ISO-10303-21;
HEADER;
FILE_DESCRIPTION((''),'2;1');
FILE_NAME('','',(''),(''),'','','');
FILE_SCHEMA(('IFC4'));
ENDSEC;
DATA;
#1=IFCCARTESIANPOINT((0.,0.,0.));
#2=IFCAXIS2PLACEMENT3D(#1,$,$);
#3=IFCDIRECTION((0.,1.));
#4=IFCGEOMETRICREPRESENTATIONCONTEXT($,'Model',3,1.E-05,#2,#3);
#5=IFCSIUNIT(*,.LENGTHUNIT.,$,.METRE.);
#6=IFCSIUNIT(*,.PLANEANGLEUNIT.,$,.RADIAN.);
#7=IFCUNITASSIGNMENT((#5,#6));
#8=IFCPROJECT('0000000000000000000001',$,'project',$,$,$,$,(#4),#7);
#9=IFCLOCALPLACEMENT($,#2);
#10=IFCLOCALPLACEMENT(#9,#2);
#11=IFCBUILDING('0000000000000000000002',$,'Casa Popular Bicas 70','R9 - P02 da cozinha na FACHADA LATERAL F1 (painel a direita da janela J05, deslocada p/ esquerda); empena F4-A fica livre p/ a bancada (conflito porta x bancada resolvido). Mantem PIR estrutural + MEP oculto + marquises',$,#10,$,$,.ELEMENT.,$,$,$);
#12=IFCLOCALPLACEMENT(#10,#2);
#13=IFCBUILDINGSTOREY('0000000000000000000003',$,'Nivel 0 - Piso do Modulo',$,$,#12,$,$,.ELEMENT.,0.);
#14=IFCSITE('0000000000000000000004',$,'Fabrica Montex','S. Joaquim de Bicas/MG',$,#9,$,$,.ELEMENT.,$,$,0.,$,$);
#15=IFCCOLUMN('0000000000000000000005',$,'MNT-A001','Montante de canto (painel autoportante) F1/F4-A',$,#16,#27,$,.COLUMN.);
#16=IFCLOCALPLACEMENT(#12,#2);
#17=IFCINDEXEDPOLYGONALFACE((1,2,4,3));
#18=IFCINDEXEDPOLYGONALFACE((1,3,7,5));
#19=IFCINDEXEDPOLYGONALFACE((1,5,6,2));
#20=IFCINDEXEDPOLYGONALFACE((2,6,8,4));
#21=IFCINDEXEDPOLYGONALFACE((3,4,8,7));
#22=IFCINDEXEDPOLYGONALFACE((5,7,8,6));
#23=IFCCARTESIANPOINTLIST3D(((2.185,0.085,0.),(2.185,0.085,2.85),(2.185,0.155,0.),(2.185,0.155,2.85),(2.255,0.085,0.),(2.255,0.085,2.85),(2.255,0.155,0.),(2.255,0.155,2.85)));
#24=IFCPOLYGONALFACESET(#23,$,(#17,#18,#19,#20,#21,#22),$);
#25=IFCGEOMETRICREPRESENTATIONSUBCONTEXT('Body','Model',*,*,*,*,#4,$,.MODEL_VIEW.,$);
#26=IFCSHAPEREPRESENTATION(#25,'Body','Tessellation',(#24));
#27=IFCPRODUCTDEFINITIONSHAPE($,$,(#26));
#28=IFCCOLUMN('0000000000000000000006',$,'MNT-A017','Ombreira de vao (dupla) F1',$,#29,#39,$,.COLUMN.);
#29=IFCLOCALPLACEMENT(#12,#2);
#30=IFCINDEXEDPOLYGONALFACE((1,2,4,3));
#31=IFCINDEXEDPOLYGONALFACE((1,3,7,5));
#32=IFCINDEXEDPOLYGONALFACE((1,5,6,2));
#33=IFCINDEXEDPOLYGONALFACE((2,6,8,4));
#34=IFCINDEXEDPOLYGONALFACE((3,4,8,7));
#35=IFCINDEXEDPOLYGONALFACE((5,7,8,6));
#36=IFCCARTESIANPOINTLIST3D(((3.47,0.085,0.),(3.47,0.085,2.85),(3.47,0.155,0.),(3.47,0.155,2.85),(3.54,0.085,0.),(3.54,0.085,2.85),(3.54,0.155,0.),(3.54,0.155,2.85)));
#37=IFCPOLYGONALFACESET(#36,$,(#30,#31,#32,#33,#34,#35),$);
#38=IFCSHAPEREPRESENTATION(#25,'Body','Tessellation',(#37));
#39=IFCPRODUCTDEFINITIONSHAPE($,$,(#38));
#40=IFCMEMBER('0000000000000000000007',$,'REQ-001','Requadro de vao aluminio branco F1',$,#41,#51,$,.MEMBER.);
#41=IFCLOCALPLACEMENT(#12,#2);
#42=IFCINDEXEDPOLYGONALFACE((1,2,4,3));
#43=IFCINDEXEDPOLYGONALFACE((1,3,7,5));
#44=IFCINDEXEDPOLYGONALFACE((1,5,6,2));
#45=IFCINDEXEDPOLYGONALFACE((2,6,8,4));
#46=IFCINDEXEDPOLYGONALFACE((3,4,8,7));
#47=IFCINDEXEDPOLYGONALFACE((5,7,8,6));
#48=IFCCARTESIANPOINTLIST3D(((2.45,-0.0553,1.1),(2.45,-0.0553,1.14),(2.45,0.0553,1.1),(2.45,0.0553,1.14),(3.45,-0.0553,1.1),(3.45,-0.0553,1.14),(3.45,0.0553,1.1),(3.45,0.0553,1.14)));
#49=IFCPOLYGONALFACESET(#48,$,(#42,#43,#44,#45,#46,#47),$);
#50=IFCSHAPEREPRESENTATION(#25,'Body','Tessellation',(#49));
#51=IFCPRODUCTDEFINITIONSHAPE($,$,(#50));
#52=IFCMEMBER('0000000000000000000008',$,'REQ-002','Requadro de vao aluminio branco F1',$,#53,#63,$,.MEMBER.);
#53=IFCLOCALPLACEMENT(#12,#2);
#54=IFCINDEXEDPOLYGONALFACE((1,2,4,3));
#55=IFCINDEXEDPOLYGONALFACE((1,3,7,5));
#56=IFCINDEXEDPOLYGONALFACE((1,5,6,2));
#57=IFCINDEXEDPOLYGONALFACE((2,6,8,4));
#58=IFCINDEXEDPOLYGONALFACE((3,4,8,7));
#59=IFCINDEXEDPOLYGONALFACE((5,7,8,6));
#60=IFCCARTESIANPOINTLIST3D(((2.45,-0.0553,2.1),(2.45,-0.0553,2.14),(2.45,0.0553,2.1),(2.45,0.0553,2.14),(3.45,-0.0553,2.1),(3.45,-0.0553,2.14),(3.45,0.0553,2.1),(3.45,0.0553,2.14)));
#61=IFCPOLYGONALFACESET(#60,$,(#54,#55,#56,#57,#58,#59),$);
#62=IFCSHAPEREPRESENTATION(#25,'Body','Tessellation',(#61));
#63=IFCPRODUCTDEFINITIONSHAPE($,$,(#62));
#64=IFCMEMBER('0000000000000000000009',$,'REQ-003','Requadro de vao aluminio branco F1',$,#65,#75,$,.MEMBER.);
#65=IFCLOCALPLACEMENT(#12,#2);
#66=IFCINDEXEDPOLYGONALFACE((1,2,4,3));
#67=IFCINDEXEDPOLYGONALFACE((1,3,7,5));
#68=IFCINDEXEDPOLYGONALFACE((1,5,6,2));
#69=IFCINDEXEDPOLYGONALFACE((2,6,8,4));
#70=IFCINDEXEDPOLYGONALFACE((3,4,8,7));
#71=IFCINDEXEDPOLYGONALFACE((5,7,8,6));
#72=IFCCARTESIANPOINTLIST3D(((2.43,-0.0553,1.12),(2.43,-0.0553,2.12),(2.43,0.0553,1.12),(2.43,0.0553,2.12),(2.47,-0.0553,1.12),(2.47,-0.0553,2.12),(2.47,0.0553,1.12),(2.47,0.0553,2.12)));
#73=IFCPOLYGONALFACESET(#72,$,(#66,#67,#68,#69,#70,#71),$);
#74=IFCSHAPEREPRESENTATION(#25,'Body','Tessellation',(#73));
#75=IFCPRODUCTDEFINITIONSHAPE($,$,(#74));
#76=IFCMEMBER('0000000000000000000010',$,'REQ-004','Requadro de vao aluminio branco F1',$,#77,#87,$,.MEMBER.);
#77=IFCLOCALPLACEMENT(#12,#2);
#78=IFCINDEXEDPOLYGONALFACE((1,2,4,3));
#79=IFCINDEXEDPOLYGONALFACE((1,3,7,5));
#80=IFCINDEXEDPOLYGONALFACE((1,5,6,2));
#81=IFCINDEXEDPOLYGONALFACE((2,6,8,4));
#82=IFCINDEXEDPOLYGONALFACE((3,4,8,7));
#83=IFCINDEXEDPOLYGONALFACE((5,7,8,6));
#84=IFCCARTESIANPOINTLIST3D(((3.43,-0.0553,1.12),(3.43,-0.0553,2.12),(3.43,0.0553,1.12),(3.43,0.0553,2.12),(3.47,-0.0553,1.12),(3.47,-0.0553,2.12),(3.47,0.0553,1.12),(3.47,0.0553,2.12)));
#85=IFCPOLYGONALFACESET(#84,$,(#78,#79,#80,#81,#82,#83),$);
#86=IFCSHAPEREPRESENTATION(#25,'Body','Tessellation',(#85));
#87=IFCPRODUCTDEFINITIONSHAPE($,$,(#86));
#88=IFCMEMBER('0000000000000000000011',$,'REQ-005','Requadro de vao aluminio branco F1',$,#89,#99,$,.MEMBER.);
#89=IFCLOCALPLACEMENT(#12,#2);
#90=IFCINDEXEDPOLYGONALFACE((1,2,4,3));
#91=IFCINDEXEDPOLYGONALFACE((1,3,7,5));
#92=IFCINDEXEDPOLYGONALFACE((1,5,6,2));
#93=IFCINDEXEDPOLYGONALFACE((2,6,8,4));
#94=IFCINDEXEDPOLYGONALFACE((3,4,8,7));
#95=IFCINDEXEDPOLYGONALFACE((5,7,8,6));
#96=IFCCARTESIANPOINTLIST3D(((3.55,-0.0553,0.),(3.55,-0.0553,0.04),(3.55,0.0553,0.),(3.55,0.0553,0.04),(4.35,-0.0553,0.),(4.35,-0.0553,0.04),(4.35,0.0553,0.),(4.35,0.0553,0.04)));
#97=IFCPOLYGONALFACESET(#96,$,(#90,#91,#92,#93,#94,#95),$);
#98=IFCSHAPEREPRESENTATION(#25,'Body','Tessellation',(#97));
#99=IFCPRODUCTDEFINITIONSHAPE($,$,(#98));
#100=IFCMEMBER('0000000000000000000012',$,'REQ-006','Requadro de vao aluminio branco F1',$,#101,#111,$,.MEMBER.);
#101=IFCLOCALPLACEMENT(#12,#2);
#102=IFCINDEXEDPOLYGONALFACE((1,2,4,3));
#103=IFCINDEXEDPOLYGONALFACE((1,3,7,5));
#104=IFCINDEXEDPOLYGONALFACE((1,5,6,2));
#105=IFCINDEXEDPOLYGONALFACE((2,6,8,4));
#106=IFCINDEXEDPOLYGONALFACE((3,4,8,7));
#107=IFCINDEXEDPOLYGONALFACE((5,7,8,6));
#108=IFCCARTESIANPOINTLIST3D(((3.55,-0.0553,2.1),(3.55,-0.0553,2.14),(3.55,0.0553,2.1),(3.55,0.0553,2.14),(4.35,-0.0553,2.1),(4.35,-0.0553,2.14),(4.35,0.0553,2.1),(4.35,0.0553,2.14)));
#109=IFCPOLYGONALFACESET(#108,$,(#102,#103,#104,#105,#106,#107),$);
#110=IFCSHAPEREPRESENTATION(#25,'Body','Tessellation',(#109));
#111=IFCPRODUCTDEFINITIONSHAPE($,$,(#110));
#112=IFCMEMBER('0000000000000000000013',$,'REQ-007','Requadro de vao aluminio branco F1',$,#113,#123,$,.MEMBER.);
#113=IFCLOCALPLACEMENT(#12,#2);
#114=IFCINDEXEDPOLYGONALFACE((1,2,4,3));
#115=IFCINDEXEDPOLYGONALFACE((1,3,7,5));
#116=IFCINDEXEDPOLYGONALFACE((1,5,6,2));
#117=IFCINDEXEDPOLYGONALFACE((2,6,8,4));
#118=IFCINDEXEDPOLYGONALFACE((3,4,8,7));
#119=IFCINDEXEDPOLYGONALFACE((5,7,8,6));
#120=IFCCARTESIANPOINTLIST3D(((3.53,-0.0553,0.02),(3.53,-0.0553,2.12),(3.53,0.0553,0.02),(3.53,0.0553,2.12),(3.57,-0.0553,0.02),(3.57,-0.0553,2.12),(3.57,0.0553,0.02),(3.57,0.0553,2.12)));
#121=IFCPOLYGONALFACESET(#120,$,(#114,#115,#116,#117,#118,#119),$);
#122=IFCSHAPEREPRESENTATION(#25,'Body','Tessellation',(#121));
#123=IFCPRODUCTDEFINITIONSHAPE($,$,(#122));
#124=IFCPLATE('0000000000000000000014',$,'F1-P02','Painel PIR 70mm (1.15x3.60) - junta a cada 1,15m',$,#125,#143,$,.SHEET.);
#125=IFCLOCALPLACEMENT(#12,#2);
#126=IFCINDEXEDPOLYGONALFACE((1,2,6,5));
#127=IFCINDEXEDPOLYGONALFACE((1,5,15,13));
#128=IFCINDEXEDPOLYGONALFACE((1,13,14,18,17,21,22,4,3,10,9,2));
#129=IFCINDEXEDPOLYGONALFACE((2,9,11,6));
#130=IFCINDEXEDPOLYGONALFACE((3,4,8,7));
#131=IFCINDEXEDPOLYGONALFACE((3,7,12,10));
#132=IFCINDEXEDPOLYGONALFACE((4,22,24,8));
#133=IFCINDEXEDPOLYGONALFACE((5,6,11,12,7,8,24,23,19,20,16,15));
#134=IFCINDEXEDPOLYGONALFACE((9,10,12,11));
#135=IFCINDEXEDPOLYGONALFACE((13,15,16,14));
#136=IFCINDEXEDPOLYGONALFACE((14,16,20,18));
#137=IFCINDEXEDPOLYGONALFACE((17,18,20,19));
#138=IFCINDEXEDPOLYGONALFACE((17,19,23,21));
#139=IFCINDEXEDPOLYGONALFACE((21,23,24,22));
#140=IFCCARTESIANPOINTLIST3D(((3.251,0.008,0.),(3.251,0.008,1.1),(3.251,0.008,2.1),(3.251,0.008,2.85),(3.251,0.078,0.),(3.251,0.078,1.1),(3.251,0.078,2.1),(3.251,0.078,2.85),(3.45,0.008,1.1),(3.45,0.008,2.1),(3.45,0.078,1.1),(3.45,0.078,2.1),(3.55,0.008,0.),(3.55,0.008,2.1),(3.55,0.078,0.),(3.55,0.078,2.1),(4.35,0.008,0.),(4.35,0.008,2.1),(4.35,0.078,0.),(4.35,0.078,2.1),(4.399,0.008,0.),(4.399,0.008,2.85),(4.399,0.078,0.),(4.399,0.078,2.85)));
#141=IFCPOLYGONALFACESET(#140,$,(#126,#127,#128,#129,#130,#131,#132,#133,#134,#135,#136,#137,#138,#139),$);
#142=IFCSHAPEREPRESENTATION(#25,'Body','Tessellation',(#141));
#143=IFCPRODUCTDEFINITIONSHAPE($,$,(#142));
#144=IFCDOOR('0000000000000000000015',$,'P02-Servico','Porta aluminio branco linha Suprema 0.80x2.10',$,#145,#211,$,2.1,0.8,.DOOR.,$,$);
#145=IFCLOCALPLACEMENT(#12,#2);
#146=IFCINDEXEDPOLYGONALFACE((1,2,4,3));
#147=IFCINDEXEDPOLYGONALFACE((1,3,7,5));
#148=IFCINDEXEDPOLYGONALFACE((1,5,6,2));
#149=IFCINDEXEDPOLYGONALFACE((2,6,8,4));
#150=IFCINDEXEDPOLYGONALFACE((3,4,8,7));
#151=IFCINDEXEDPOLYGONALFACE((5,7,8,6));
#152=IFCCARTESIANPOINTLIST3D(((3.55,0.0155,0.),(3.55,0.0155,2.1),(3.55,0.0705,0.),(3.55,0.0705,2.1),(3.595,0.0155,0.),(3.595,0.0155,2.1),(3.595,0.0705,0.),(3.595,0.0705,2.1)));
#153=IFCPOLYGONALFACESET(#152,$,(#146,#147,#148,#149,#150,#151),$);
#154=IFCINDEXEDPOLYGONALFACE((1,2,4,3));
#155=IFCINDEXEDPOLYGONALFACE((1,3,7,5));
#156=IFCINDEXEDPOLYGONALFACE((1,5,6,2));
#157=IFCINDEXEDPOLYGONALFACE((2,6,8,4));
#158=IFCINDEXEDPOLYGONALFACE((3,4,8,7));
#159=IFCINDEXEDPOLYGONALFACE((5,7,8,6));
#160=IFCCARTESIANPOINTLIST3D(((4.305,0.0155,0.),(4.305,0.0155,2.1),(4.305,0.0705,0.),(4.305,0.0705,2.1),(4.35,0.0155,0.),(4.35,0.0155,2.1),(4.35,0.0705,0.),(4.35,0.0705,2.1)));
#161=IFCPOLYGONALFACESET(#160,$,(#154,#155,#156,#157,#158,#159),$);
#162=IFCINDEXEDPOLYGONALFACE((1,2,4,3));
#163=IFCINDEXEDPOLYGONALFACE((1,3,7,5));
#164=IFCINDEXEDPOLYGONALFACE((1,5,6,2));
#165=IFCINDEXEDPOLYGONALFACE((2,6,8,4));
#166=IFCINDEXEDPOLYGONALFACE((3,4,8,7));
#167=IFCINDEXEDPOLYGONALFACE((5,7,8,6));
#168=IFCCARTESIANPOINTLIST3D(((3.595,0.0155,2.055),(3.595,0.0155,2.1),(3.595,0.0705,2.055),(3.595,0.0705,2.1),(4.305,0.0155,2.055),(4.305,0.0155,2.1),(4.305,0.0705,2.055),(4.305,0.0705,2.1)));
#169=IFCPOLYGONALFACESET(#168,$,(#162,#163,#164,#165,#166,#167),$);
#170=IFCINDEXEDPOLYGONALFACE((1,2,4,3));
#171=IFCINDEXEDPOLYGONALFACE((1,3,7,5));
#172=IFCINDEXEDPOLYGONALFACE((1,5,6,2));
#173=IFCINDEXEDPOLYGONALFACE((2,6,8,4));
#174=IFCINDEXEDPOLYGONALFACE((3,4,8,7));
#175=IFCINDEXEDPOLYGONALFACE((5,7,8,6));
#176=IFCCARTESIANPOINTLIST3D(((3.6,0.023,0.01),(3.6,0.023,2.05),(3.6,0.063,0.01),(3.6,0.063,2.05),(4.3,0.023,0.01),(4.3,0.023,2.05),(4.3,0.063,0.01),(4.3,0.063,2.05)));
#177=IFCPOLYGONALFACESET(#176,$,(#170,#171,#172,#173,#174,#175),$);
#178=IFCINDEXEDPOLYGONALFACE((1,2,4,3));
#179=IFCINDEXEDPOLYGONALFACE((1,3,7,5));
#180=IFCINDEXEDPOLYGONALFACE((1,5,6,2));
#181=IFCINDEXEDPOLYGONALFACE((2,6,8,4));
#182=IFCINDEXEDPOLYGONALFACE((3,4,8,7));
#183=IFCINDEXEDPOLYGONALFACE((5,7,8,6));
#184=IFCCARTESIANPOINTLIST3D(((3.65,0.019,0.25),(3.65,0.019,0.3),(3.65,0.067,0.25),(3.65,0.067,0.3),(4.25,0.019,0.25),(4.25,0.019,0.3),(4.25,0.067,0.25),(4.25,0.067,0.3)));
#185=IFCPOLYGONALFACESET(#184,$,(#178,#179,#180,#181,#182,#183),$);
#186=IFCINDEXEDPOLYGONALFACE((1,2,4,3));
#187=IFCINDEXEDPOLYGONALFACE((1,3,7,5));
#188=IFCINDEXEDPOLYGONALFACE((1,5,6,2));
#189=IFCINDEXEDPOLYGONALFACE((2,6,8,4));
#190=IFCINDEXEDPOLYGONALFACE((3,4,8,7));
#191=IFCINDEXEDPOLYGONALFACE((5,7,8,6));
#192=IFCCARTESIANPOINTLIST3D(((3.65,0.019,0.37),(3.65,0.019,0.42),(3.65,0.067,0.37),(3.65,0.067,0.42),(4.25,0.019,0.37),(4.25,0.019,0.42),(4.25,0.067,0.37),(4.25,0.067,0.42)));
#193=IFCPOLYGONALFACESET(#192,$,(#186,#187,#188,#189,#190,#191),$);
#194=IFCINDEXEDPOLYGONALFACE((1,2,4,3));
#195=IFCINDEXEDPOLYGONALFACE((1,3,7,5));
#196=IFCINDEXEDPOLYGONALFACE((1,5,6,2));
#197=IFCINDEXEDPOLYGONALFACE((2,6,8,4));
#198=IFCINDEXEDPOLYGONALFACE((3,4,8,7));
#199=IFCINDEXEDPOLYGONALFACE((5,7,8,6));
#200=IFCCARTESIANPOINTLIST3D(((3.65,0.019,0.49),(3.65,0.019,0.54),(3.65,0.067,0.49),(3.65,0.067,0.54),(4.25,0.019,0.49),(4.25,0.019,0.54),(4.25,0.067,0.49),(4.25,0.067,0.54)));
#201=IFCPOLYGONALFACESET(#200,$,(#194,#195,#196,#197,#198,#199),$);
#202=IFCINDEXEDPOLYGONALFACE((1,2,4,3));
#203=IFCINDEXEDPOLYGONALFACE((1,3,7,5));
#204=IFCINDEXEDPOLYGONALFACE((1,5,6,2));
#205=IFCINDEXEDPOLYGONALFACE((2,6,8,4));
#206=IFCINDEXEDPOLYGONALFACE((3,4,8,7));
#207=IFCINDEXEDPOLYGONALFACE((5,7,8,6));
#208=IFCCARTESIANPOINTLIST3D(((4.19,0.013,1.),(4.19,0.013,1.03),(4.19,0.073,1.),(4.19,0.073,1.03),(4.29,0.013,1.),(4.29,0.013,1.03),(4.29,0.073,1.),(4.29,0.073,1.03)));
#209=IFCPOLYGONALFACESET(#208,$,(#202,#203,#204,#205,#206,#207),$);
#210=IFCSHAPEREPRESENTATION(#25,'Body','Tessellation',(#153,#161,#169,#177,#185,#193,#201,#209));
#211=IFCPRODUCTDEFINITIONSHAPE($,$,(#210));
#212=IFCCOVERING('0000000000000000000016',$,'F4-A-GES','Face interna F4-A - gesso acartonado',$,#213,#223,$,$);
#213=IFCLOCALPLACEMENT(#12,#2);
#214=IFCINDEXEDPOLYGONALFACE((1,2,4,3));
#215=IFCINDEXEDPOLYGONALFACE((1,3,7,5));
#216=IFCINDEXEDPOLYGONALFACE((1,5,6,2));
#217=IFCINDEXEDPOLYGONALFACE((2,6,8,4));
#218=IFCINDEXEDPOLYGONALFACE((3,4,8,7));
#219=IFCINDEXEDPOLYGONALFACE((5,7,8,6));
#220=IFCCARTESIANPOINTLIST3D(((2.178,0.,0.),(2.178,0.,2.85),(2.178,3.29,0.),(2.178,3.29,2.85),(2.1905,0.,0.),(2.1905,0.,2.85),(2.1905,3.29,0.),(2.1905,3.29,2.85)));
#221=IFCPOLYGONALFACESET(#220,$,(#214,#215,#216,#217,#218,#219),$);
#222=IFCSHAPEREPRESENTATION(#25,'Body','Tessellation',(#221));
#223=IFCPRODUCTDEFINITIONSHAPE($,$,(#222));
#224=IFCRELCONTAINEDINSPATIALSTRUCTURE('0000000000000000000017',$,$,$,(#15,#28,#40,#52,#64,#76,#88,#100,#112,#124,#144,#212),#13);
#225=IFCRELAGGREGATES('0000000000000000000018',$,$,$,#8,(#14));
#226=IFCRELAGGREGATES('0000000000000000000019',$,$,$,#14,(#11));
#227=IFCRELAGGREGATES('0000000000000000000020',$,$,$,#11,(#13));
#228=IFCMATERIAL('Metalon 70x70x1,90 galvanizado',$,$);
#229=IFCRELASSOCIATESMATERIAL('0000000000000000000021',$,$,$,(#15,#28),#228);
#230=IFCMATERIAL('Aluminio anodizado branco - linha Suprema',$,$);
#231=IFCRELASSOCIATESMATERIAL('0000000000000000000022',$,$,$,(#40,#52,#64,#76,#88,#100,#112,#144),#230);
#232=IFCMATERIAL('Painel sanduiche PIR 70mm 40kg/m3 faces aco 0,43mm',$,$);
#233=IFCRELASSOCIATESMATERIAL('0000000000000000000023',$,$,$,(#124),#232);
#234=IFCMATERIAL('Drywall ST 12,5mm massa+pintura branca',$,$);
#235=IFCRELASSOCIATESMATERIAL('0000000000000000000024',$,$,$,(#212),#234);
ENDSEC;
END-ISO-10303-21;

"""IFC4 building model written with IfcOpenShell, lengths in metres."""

from ifc_helpers import new_model, si_unit, direction, frame, frame_2d, origin, origin_2d, place, context, subcontext, project, spatial, rectangle, extrude, material, element, fill, save


model = new_model("IFC4")

# Units and contexts
model_context = context("Model", 3, precision=1e-05, world=origin(), true_north=direction((0.0, 1.0)))
body_context = subcontext(model_context, "Body", "Model", "MODEL_VIEW")
ifc_project = project(units=[si_unit("LENGTHUNIT", "METRE"), si_unit("PLANEANGLEUNIT", "RADIAN")], contexts=[model_context])

# Site, building, storey
site_placement = place(None, origin())
site = spatial("IfcSite", under=ifc_project, at=site_placement, Name="Fabrica Montex", Description="S. Joaquim de Bicas/MG", CompositionType="ELEMENT", RefElevation=0.0)
building_placement = place(site_placement, origin())
building = spatial("IfcBuilding", under=site, at=building_placement, Name="Casa Popular Bicas 70", Description="R9 - P02 da cozinha na FACHADA LATERAL F1 (painel a direita da janela J05, deslocada p/ esquerda); empena F4-A fica livre p/ a bancada (conflito porta x bancada resolvido). Mantem PIR estrutural + MEP oculto + marquises", CompositionType="ELEMENT")
storey_placement = place(building_placement, origin())
storey = spatial("IfcBuildingStorey", under=building, at=storey_placement, Name="Nivel 0 - Piso do Modulo", CompositionType="ELEMENT", Elevation=0.0)

# Columns
ifc_material_1 = material(Name="Metalon 70x70x1,90 galvanizado")
for number, where, name, description in (
    (1, (2.22, 0.12, 0.0), "MNT-A001", "Montante de canto (painel autoportante) F1/F4-A"),
    (2, (3.505, 0.12, 0.0), "MNT-A017", "Ombreira de vao (dupla) F1"),
):
    element("IfcColumn", number, at=place(storey_placement, frame(where)), inside=storey, material=ifc_material_1, Name=name, Description=description, PredefinedType="COLUMN", context=body_context, shape_type="SweptSolid", body=[
        extrude(rectangle(XDim=0.07, YDim=0.07, at=origin_2d()), origin(), (0.0, 0.0, 1.0), 2.85),
    ])

# Members
ifc_material_2 = material(Name="Aluminio anodizado branco - linha Suprema")
for number, where, z_axis, x_axis, name in (
    (3, (2.45, 0.0, 1.12), (1.0, 0.0, 0.0), (0.0, 0.0, 1.0), "REQ-001"),
    (4, (2.45, 0.0, 2.12), (1.0, 0.0, 0.0), (0.0, 0.0, 1.0), "REQ-002"),
    (5, (2.45, 0.0, 1.12), (0.0, 0.0, 1.0), (1.0, 0.0, 0.0), "REQ-003"),
    (6, (3.45, 0.0, 1.12), (0.0, 0.0, 1.0), (1.0, 0.0, 0.0), "REQ-004"),
):
    element("IfcMember", number, at=place(storey_placement, frame(where, z_axis=z_axis, x_axis=x_axis)), inside=storey, material=ifc_material_2, Name=name, Description="Requadro de vao aluminio branco F1", PredefinedType="MEMBER", context=body_context, shape_type="SweptSolid", body=[
        extrude(rectangle(XDim=0.04, YDim=0.1105, at=origin_2d()), origin(), (0.0, 0.0, 1.0), 1.0),
    ])
for number, where, z_axis, x_axis, name in (
    (7, (3.55, 0.0, 0.02), (1.0, 0.0, 0.0), (0.0, 0.0, 1.0), "REQ-005"),
    (8, (3.55, 0.0, 2.12), (1.0, 0.0, 0.0), (0.0, 0.0, 1.0), "REQ-006"),
):
    element("IfcMember", number, at=place(storey_placement, frame(where, z_axis=z_axis, x_axis=x_axis)), inside=storey, material=ifc_material_2, Name=name, Description="Requadro de vao aluminio branco F1", PredefinedType="MEMBER", context=body_context, shape_type="SweptSolid", body=[
        extrude(rectangle(XDim=0.04, YDim=0.1105, at=origin_2d()), origin(), (0.0, 0.0, 1.0), 0.8),
    ])
member_placement = place(storey_placement, frame((3.55, 0.0, 0.02), z_axis=(0.0, 0.0, 1.0), x_axis=(1.0, 0.0, 0.0)))
element("IfcMember", 9, at=member_placement, inside=storey, material=ifc_material_2, Name="REQ-007", Description="Requadro de vao aluminio branco F1", PredefinedType="MEMBER", context=body_context, shape_type="SweptSolid", body=[
    extrude(rectangle(XDim=0.04, YDim=0.1105, at=origin_2d()), origin(), (0.0, 0.0, 1.0), 2.1),
])

# Plate, openings, door
ifc_material_3 = material(Name="Painel sanduiche PIR 70mm 40kg/m3 faces aco 0,43mm")
plate_placement = place(storey_placement, frame((3.251, 0.043, 0.0), x_axis=(1.0, 0.0, 0.0)))
plate = element("IfcPlate", 10, at=plate_placement, inside=storey, material=ifc_material_3, Name="F1-P02", Description="Painel PIR 70mm (1.15x3.60) - junta a cada 1,15m", PredefinedType="SHEET", context=body_context, shape_type="SweptSolid", body=[
    extrude(rectangle(XDim=1.148, YDim=0.07, at=frame_2d((0.574, 0.0))), origin(), (0.0, 0.0, 1.0), 2.85),
])
opening_1_placement = place(storey_placement, frame((3.35, 0.043, 1.1)))
element("IfcOpeningElement", 11, at=opening_1_placement, cuts=plate, PredefinedType="OPENING", context=body_context, shape_type="SweptSolid", body=[
    extrude(rectangle(XDim=0.2, YDim=0.1, at=origin_2d()), origin(), (0.0, 0.0, 1.0), 1.0),
])
opening_2_placement = place(storey_placement, frame((3.95, 0.043, 0.0)))
opening_2 = element("IfcOpeningElement", 12, at=opening_2_placement, cuts=plate, PredefinedType="OPENING", context=body_context, shape_type="SweptSolid", body=[
    extrude(rectangle(XDim=0.8, YDim=0.1, at=origin_2d()), origin(), (0.0, 0.0, 1.0), 2.1),
])
door_placement = place(storey_placement, frame((3.55, 0.043, 0.0), x_axis=(1.0, 0.0, 0.0)))
door = element("IfcDoor", 13, at=door_placement, inside=storey, material=ifc_material_2, Name="P02-Servico", Description="Porta aluminio branco linha Suprema 0.80x2.10", OverallHeight=2.1, OverallWidth=0.8, PredefinedType="DOOR", context=body_context, shape_type="SweptSolid", body=[
    extrude(rectangle(XDim=0.045, YDim=0.055, at=frame_2d((0.0225, 0.0))), origin(), (0.0, 0.0, 1.0), 2.1),
    extrude(rectangle(XDim=0.045, YDim=0.055, at=frame_2d((0.7775, 0.0))), origin(), (0.0, 0.0, 1.0), 2.1),
    extrude(rectangle(XDim=0.71, YDim=0.055, at=frame_2d((0.4, 0.0))), frame((0.0, 0.0, 2.055)), (0.0, 0.0, 1.0), 0.045),
    extrude(rectangle(XDim=0.7, YDim=0.04, at=frame_2d((0.4, 0.0))), frame((0.0, 0.0, 0.01)), (0.0, 0.0, 1.0), 2.04),
    extrude(rectangle(XDim=0.6, YDim=0.048, at=frame_2d((0.4, 0.0))), frame((0.0, 0.0, 0.25)), (0.0, 0.0, 1.0), 0.05),
    extrude(rectangle(XDim=0.6, YDim=0.048, at=frame_2d((0.4, 0.0))), frame((0.0, 0.0, 0.37)), (0.0, 0.0, 1.0), 0.05),
    extrude(rectangle(XDim=0.6, YDim=0.048, at=frame_2d((0.4, 0.0))), frame((0.0, 0.0, 0.49)), (0.0, 0.0, 1.0), 0.05),
    extrude(rectangle(XDim=0.1, YDim=0.06, at=frame_2d((0.69, 0.0))), frame((0.0, 0.0, 1.0)), (0.0, 0.0, 1.0), 0.03),
])
fill(opening_2, door)

# Covering
ifc_material_4 = material(Name="Drywall ST 12,5mm massa+pintura branca")
covering_1_placement = place(storey_placement, frame((2.1843, 0.0, 0.0), x_axis=(0.0, 1.0, 0.0)))
element("IfcCovering", 14, at=covering_1_placement, inside=storey, material=ifc_material_4, Name="F4-A-GES", Description="Face interna F4-A - gesso acartonado", context=body_context, shape_type="SweptSolid", body=[
    extrude(rectangle(XDim=3.29, YDim=0.0125, at=frame_2d((1.645, 0.0))), origin(), (0.0, 0.0, 1.0), 2.85),
])

save(model, "model.ifc")
